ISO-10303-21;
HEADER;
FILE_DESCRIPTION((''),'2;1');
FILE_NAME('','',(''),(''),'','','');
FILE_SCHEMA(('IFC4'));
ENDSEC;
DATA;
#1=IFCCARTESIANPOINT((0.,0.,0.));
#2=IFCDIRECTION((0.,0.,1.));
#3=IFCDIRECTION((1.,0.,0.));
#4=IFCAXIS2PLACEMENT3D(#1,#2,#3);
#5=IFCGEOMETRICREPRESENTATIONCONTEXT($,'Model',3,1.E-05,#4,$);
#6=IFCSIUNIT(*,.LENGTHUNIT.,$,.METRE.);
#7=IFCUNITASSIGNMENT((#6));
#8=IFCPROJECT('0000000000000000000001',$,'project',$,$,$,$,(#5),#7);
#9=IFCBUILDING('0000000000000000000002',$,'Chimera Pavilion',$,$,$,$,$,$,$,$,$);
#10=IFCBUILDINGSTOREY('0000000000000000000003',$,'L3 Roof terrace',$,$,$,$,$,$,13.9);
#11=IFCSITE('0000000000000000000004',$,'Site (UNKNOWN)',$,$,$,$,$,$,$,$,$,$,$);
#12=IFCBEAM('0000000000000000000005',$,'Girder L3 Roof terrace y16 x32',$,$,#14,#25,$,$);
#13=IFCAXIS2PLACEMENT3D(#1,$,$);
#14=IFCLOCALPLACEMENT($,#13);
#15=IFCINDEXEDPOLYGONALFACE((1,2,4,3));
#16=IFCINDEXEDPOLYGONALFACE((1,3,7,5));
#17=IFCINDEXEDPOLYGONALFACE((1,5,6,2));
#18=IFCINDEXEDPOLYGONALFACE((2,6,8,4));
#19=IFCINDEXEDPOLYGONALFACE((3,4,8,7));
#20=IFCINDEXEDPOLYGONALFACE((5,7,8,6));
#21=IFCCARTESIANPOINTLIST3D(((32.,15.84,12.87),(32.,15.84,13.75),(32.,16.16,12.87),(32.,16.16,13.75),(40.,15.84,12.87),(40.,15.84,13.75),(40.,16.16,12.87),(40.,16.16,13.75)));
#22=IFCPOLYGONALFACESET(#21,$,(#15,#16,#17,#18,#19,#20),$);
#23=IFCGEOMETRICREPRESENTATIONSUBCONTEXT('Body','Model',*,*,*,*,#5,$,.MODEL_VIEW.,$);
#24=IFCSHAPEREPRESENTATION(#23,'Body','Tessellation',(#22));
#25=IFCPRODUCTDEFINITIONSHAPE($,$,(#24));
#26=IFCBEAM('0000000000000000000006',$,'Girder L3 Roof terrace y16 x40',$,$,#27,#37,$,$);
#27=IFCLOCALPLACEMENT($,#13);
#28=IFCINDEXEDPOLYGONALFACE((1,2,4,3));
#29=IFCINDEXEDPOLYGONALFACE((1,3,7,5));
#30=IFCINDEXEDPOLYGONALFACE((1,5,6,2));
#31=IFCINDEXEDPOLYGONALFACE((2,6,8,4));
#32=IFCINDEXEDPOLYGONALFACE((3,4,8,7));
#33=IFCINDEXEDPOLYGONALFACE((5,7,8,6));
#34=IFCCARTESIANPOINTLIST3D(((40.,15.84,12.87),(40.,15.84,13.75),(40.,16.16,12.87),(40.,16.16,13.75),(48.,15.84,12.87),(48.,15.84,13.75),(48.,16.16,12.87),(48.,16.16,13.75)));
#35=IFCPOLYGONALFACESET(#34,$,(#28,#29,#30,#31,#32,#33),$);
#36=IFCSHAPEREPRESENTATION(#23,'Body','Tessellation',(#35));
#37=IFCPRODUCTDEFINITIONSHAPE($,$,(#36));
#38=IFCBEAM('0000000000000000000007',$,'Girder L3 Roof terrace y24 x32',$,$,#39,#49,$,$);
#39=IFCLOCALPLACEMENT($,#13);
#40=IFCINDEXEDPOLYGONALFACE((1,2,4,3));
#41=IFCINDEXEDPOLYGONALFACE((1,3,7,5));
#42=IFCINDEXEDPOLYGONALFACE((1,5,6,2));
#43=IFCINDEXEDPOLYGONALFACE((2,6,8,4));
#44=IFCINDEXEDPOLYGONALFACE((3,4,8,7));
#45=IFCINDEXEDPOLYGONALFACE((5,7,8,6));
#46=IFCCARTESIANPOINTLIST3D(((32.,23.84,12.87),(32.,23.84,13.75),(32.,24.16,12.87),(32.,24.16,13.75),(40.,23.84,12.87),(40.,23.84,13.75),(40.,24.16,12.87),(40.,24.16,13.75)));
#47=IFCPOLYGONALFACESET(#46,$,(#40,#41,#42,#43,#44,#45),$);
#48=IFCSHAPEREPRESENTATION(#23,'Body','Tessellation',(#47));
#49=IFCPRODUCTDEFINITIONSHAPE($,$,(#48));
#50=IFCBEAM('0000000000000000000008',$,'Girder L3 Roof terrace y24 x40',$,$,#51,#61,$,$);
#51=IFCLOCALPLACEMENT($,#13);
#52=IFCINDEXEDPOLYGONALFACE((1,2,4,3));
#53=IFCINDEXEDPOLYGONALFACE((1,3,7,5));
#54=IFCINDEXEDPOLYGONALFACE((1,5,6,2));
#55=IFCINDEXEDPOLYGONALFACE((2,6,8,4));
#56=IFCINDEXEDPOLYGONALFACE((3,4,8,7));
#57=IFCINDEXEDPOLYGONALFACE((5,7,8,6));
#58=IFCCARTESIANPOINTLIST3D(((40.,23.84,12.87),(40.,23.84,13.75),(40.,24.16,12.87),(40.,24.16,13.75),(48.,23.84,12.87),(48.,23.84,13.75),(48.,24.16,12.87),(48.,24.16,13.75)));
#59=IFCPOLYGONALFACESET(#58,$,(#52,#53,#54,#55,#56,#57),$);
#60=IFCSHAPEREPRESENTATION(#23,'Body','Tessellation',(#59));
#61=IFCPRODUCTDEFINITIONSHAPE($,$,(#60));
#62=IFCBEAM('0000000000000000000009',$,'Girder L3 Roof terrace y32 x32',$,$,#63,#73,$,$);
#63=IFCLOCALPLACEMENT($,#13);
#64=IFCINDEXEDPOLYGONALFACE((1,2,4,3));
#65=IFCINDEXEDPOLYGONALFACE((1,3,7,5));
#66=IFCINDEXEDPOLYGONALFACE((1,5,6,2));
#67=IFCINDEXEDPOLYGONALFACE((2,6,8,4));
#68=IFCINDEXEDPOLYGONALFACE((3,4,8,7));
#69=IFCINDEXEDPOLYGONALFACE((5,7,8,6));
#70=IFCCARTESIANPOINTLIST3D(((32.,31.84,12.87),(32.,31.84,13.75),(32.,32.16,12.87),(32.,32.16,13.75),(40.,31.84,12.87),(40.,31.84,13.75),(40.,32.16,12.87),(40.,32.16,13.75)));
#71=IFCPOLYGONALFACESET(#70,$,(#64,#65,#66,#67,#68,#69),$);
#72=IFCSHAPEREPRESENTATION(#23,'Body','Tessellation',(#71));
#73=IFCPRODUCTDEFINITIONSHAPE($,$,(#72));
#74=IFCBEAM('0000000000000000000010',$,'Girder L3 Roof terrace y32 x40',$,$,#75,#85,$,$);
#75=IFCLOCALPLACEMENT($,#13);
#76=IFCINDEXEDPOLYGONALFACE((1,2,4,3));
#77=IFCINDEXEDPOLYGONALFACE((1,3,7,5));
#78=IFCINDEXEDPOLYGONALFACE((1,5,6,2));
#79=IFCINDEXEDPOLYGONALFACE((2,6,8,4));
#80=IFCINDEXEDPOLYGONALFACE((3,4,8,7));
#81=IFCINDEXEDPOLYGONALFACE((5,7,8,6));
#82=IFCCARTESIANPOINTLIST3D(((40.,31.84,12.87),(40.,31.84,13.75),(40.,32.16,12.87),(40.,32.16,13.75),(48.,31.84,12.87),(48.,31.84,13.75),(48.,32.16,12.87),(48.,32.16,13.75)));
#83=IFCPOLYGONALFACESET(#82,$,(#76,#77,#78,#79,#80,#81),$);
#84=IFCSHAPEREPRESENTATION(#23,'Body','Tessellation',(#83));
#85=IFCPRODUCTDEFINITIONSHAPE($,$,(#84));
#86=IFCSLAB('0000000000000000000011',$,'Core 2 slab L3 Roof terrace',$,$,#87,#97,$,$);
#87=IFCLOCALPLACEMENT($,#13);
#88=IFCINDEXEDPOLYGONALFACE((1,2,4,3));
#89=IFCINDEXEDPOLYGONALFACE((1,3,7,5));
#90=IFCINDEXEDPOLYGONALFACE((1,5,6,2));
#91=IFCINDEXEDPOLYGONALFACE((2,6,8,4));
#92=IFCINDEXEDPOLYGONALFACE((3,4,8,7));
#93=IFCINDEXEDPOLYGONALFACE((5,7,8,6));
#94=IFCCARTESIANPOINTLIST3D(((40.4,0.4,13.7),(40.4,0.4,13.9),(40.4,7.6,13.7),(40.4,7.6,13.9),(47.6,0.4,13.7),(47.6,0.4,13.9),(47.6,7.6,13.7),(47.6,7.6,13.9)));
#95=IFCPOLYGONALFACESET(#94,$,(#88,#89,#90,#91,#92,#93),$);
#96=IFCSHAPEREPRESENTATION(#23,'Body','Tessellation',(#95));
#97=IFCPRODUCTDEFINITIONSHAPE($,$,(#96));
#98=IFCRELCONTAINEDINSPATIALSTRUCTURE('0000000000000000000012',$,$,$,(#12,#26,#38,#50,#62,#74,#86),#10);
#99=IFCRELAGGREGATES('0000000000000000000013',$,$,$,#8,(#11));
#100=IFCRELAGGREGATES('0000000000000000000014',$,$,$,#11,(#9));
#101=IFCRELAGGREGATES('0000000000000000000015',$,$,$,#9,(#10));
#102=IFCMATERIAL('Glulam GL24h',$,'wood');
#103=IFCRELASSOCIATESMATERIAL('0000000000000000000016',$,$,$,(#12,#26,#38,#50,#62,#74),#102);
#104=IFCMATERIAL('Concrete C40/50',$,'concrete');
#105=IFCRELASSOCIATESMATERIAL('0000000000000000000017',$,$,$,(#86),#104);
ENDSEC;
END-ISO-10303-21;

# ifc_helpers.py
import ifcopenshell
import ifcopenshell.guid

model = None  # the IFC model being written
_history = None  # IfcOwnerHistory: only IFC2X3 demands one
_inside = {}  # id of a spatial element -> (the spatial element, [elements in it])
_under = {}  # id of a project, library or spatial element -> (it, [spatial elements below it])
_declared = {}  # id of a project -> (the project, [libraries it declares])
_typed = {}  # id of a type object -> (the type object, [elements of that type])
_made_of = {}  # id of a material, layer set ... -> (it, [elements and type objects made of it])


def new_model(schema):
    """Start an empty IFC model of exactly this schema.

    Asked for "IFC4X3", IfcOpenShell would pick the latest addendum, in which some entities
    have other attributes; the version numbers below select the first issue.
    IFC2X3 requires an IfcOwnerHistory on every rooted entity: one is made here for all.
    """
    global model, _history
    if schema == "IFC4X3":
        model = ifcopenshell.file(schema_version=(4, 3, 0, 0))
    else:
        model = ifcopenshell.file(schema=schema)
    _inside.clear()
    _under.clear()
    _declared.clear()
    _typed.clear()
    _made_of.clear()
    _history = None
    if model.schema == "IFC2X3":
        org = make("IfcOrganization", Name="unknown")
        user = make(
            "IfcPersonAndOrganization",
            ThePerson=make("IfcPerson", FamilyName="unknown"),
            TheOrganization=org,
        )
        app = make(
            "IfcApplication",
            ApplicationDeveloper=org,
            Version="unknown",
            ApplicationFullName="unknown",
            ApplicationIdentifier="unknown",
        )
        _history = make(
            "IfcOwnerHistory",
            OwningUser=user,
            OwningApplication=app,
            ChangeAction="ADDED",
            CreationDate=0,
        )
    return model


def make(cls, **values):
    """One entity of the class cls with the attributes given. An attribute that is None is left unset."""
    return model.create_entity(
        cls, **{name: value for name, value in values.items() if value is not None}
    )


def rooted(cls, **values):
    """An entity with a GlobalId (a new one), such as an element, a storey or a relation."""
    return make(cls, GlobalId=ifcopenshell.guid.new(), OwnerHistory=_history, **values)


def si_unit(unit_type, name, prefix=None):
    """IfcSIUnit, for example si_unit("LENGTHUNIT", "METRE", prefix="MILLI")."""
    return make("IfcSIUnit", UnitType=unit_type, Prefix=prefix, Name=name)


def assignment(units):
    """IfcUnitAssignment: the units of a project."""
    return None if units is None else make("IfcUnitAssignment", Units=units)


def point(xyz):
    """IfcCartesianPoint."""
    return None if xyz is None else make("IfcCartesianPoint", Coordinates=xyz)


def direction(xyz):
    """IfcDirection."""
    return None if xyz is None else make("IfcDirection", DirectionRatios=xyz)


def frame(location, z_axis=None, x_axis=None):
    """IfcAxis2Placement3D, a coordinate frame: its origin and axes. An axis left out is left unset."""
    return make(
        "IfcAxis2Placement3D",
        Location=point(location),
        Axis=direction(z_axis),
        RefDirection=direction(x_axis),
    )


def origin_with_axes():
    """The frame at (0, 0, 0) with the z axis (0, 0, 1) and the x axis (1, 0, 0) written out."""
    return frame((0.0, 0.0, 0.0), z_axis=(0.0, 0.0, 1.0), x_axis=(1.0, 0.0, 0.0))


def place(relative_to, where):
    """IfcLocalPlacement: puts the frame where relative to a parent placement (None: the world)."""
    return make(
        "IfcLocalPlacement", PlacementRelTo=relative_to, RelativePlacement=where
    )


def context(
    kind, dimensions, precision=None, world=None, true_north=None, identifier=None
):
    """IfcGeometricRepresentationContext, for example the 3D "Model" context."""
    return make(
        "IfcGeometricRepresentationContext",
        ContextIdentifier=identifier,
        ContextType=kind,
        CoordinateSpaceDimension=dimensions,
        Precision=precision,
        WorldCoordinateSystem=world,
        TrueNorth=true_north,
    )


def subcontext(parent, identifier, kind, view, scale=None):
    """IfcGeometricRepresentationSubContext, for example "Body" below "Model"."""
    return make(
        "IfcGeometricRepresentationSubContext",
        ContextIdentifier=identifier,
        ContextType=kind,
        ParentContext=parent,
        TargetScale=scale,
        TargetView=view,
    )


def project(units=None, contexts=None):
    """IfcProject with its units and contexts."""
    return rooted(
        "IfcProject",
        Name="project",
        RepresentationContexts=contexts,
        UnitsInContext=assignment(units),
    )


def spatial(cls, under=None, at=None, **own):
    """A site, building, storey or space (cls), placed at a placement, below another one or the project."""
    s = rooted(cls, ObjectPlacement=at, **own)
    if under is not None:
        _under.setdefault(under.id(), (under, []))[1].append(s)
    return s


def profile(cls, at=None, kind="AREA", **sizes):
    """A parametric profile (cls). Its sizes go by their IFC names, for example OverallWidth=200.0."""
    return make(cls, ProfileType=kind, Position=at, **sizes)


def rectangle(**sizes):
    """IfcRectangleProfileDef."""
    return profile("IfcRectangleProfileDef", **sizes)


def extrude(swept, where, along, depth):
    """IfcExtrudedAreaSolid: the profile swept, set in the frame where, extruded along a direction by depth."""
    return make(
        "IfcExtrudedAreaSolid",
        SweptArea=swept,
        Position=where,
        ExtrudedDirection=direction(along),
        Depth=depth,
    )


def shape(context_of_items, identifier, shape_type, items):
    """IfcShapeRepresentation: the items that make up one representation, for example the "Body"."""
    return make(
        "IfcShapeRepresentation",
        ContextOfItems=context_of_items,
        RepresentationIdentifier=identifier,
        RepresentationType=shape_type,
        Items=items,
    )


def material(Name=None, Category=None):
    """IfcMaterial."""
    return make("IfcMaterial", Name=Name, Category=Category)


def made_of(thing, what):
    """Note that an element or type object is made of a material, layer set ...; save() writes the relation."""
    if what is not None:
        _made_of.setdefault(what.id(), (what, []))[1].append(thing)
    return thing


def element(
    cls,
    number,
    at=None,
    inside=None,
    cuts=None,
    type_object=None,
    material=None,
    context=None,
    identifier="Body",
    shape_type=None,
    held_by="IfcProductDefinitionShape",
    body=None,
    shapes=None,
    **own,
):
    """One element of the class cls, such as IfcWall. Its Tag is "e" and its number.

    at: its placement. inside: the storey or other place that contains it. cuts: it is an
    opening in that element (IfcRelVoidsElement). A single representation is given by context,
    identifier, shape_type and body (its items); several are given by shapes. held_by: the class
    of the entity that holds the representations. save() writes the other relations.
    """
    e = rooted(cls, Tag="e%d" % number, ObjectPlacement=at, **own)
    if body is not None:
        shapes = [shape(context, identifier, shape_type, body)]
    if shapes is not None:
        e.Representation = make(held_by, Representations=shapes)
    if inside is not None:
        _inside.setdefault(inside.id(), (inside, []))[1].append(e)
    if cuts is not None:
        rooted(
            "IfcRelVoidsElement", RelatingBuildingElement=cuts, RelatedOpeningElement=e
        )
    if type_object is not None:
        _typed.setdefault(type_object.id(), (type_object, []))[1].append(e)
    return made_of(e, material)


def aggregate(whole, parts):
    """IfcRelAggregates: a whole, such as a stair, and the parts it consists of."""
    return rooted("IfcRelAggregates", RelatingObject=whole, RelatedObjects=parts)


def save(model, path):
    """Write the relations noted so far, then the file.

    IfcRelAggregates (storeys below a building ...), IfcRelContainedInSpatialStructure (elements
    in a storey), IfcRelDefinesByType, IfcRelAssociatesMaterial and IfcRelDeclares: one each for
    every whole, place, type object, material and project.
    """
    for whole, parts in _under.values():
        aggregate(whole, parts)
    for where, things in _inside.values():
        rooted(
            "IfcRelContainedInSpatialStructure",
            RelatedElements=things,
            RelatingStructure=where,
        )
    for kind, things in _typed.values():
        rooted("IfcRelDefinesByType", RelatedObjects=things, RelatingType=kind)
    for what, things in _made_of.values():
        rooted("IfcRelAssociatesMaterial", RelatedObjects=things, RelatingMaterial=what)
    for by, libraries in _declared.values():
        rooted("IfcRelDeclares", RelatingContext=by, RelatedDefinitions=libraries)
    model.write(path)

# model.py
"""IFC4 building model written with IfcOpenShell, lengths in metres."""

from ifc_helpers import new_model, si_unit, frame, origin_with_axes, place, context, subcontext, project, spatial, rectangle, extrude, material, element, save


model = new_model("IFC4")

# Units and contexts
model_context = context("Model", 3, precision=1e-05, world=origin_with_axes())
body_context = subcontext(model_context, "Body", "Model", "MODEL_VIEW")
ifc_project = project(units=[si_unit("LENGTHUNIT", "METRE")], contexts=[model_context])

# Site, building, storey
site = spatial("IfcSite", under=ifc_project, Name="Site (UNKNOWN)")
building = spatial("IfcBuilding", under=site, Name="Chimera Pavilion")
storey = spatial("IfcBuildingStorey", under=building, Name="L3 Roof terrace", Elevation=13.9)

# Beams
ifc_material_1 = material(Name="Glulam GL24h", Category="wood")
for number, where, z_axis, x_axis, name in (
    (1, (32.0, 16.0, 13.31), (1.0, 0.0, 0.0), (0.0, -1.0, 0.0), "Girder L3 Roof terrace y16 x32"),
    (2, (40.0, 16.0, 13.31), (1.0, 0.0, 0.0), (0.0, -1.0, 0.0), "Girder L3 Roof terrace y16 x40"),
    (3, (32.0, 24.0, 13.31), (1.0, 0.0, 0.0), (0.0, -1.0, 0.0), "Girder L3 Roof terrace y24 x32"),
    (4, (40.0, 24.0, 13.31), (1.0, 0.0, 0.0), (0.0, -1.0, 0.0), "Girder L3 Roof terrace y24 x40"),
    (5, (32.0, 32.0, 13.31), (1.0, 0.0, 0.0), (0.0, -1.0, 0.0), "Girder L3 Roof terrace y32 x32"),
    (6, (40.0, 32.0, 13.31), (1.0, 0.0, 0.0), (0.0, -1.0, 0.0), "Girder L3 Roof terrace y32 x40"),
):
    element("IfcBeam", number, at=place(None, frame(where, z_axis=z_axis, x_axis=x_axis)), inside=storey, material=ifc_material_1, Name=name, context=body_context, shape_type="SweptSolid", body=[
        extrude(rectangle(XDim=0.32, YDim=0.88), origin_with_axes(), (0.0, 0.0, 1.0), 8.0),
    ])

# Slab
ifc_material_2 = material(Name="Concrete C40/50", Category="concrete")
slab_placement = place(None, frame((44.0, 4.0, 13.7), z_axis=(0.0, 0.0, 1.0), x_axis=(1.0, 0.0, 0.0)))
element("IfcSlab", 7, at=slab_placement, inside=storey, material=ifc_material_2, Name="Core 2 slab L3 Roof terrace", context=body_context, shape_type="SweptSolid", body=[
    extrude(rectangle(XDim=7.2, YDim=7.2), origin_with_axes(), (0.0, 0.0, 1.0), 0.2),
])

save(model, "model.ifc")
